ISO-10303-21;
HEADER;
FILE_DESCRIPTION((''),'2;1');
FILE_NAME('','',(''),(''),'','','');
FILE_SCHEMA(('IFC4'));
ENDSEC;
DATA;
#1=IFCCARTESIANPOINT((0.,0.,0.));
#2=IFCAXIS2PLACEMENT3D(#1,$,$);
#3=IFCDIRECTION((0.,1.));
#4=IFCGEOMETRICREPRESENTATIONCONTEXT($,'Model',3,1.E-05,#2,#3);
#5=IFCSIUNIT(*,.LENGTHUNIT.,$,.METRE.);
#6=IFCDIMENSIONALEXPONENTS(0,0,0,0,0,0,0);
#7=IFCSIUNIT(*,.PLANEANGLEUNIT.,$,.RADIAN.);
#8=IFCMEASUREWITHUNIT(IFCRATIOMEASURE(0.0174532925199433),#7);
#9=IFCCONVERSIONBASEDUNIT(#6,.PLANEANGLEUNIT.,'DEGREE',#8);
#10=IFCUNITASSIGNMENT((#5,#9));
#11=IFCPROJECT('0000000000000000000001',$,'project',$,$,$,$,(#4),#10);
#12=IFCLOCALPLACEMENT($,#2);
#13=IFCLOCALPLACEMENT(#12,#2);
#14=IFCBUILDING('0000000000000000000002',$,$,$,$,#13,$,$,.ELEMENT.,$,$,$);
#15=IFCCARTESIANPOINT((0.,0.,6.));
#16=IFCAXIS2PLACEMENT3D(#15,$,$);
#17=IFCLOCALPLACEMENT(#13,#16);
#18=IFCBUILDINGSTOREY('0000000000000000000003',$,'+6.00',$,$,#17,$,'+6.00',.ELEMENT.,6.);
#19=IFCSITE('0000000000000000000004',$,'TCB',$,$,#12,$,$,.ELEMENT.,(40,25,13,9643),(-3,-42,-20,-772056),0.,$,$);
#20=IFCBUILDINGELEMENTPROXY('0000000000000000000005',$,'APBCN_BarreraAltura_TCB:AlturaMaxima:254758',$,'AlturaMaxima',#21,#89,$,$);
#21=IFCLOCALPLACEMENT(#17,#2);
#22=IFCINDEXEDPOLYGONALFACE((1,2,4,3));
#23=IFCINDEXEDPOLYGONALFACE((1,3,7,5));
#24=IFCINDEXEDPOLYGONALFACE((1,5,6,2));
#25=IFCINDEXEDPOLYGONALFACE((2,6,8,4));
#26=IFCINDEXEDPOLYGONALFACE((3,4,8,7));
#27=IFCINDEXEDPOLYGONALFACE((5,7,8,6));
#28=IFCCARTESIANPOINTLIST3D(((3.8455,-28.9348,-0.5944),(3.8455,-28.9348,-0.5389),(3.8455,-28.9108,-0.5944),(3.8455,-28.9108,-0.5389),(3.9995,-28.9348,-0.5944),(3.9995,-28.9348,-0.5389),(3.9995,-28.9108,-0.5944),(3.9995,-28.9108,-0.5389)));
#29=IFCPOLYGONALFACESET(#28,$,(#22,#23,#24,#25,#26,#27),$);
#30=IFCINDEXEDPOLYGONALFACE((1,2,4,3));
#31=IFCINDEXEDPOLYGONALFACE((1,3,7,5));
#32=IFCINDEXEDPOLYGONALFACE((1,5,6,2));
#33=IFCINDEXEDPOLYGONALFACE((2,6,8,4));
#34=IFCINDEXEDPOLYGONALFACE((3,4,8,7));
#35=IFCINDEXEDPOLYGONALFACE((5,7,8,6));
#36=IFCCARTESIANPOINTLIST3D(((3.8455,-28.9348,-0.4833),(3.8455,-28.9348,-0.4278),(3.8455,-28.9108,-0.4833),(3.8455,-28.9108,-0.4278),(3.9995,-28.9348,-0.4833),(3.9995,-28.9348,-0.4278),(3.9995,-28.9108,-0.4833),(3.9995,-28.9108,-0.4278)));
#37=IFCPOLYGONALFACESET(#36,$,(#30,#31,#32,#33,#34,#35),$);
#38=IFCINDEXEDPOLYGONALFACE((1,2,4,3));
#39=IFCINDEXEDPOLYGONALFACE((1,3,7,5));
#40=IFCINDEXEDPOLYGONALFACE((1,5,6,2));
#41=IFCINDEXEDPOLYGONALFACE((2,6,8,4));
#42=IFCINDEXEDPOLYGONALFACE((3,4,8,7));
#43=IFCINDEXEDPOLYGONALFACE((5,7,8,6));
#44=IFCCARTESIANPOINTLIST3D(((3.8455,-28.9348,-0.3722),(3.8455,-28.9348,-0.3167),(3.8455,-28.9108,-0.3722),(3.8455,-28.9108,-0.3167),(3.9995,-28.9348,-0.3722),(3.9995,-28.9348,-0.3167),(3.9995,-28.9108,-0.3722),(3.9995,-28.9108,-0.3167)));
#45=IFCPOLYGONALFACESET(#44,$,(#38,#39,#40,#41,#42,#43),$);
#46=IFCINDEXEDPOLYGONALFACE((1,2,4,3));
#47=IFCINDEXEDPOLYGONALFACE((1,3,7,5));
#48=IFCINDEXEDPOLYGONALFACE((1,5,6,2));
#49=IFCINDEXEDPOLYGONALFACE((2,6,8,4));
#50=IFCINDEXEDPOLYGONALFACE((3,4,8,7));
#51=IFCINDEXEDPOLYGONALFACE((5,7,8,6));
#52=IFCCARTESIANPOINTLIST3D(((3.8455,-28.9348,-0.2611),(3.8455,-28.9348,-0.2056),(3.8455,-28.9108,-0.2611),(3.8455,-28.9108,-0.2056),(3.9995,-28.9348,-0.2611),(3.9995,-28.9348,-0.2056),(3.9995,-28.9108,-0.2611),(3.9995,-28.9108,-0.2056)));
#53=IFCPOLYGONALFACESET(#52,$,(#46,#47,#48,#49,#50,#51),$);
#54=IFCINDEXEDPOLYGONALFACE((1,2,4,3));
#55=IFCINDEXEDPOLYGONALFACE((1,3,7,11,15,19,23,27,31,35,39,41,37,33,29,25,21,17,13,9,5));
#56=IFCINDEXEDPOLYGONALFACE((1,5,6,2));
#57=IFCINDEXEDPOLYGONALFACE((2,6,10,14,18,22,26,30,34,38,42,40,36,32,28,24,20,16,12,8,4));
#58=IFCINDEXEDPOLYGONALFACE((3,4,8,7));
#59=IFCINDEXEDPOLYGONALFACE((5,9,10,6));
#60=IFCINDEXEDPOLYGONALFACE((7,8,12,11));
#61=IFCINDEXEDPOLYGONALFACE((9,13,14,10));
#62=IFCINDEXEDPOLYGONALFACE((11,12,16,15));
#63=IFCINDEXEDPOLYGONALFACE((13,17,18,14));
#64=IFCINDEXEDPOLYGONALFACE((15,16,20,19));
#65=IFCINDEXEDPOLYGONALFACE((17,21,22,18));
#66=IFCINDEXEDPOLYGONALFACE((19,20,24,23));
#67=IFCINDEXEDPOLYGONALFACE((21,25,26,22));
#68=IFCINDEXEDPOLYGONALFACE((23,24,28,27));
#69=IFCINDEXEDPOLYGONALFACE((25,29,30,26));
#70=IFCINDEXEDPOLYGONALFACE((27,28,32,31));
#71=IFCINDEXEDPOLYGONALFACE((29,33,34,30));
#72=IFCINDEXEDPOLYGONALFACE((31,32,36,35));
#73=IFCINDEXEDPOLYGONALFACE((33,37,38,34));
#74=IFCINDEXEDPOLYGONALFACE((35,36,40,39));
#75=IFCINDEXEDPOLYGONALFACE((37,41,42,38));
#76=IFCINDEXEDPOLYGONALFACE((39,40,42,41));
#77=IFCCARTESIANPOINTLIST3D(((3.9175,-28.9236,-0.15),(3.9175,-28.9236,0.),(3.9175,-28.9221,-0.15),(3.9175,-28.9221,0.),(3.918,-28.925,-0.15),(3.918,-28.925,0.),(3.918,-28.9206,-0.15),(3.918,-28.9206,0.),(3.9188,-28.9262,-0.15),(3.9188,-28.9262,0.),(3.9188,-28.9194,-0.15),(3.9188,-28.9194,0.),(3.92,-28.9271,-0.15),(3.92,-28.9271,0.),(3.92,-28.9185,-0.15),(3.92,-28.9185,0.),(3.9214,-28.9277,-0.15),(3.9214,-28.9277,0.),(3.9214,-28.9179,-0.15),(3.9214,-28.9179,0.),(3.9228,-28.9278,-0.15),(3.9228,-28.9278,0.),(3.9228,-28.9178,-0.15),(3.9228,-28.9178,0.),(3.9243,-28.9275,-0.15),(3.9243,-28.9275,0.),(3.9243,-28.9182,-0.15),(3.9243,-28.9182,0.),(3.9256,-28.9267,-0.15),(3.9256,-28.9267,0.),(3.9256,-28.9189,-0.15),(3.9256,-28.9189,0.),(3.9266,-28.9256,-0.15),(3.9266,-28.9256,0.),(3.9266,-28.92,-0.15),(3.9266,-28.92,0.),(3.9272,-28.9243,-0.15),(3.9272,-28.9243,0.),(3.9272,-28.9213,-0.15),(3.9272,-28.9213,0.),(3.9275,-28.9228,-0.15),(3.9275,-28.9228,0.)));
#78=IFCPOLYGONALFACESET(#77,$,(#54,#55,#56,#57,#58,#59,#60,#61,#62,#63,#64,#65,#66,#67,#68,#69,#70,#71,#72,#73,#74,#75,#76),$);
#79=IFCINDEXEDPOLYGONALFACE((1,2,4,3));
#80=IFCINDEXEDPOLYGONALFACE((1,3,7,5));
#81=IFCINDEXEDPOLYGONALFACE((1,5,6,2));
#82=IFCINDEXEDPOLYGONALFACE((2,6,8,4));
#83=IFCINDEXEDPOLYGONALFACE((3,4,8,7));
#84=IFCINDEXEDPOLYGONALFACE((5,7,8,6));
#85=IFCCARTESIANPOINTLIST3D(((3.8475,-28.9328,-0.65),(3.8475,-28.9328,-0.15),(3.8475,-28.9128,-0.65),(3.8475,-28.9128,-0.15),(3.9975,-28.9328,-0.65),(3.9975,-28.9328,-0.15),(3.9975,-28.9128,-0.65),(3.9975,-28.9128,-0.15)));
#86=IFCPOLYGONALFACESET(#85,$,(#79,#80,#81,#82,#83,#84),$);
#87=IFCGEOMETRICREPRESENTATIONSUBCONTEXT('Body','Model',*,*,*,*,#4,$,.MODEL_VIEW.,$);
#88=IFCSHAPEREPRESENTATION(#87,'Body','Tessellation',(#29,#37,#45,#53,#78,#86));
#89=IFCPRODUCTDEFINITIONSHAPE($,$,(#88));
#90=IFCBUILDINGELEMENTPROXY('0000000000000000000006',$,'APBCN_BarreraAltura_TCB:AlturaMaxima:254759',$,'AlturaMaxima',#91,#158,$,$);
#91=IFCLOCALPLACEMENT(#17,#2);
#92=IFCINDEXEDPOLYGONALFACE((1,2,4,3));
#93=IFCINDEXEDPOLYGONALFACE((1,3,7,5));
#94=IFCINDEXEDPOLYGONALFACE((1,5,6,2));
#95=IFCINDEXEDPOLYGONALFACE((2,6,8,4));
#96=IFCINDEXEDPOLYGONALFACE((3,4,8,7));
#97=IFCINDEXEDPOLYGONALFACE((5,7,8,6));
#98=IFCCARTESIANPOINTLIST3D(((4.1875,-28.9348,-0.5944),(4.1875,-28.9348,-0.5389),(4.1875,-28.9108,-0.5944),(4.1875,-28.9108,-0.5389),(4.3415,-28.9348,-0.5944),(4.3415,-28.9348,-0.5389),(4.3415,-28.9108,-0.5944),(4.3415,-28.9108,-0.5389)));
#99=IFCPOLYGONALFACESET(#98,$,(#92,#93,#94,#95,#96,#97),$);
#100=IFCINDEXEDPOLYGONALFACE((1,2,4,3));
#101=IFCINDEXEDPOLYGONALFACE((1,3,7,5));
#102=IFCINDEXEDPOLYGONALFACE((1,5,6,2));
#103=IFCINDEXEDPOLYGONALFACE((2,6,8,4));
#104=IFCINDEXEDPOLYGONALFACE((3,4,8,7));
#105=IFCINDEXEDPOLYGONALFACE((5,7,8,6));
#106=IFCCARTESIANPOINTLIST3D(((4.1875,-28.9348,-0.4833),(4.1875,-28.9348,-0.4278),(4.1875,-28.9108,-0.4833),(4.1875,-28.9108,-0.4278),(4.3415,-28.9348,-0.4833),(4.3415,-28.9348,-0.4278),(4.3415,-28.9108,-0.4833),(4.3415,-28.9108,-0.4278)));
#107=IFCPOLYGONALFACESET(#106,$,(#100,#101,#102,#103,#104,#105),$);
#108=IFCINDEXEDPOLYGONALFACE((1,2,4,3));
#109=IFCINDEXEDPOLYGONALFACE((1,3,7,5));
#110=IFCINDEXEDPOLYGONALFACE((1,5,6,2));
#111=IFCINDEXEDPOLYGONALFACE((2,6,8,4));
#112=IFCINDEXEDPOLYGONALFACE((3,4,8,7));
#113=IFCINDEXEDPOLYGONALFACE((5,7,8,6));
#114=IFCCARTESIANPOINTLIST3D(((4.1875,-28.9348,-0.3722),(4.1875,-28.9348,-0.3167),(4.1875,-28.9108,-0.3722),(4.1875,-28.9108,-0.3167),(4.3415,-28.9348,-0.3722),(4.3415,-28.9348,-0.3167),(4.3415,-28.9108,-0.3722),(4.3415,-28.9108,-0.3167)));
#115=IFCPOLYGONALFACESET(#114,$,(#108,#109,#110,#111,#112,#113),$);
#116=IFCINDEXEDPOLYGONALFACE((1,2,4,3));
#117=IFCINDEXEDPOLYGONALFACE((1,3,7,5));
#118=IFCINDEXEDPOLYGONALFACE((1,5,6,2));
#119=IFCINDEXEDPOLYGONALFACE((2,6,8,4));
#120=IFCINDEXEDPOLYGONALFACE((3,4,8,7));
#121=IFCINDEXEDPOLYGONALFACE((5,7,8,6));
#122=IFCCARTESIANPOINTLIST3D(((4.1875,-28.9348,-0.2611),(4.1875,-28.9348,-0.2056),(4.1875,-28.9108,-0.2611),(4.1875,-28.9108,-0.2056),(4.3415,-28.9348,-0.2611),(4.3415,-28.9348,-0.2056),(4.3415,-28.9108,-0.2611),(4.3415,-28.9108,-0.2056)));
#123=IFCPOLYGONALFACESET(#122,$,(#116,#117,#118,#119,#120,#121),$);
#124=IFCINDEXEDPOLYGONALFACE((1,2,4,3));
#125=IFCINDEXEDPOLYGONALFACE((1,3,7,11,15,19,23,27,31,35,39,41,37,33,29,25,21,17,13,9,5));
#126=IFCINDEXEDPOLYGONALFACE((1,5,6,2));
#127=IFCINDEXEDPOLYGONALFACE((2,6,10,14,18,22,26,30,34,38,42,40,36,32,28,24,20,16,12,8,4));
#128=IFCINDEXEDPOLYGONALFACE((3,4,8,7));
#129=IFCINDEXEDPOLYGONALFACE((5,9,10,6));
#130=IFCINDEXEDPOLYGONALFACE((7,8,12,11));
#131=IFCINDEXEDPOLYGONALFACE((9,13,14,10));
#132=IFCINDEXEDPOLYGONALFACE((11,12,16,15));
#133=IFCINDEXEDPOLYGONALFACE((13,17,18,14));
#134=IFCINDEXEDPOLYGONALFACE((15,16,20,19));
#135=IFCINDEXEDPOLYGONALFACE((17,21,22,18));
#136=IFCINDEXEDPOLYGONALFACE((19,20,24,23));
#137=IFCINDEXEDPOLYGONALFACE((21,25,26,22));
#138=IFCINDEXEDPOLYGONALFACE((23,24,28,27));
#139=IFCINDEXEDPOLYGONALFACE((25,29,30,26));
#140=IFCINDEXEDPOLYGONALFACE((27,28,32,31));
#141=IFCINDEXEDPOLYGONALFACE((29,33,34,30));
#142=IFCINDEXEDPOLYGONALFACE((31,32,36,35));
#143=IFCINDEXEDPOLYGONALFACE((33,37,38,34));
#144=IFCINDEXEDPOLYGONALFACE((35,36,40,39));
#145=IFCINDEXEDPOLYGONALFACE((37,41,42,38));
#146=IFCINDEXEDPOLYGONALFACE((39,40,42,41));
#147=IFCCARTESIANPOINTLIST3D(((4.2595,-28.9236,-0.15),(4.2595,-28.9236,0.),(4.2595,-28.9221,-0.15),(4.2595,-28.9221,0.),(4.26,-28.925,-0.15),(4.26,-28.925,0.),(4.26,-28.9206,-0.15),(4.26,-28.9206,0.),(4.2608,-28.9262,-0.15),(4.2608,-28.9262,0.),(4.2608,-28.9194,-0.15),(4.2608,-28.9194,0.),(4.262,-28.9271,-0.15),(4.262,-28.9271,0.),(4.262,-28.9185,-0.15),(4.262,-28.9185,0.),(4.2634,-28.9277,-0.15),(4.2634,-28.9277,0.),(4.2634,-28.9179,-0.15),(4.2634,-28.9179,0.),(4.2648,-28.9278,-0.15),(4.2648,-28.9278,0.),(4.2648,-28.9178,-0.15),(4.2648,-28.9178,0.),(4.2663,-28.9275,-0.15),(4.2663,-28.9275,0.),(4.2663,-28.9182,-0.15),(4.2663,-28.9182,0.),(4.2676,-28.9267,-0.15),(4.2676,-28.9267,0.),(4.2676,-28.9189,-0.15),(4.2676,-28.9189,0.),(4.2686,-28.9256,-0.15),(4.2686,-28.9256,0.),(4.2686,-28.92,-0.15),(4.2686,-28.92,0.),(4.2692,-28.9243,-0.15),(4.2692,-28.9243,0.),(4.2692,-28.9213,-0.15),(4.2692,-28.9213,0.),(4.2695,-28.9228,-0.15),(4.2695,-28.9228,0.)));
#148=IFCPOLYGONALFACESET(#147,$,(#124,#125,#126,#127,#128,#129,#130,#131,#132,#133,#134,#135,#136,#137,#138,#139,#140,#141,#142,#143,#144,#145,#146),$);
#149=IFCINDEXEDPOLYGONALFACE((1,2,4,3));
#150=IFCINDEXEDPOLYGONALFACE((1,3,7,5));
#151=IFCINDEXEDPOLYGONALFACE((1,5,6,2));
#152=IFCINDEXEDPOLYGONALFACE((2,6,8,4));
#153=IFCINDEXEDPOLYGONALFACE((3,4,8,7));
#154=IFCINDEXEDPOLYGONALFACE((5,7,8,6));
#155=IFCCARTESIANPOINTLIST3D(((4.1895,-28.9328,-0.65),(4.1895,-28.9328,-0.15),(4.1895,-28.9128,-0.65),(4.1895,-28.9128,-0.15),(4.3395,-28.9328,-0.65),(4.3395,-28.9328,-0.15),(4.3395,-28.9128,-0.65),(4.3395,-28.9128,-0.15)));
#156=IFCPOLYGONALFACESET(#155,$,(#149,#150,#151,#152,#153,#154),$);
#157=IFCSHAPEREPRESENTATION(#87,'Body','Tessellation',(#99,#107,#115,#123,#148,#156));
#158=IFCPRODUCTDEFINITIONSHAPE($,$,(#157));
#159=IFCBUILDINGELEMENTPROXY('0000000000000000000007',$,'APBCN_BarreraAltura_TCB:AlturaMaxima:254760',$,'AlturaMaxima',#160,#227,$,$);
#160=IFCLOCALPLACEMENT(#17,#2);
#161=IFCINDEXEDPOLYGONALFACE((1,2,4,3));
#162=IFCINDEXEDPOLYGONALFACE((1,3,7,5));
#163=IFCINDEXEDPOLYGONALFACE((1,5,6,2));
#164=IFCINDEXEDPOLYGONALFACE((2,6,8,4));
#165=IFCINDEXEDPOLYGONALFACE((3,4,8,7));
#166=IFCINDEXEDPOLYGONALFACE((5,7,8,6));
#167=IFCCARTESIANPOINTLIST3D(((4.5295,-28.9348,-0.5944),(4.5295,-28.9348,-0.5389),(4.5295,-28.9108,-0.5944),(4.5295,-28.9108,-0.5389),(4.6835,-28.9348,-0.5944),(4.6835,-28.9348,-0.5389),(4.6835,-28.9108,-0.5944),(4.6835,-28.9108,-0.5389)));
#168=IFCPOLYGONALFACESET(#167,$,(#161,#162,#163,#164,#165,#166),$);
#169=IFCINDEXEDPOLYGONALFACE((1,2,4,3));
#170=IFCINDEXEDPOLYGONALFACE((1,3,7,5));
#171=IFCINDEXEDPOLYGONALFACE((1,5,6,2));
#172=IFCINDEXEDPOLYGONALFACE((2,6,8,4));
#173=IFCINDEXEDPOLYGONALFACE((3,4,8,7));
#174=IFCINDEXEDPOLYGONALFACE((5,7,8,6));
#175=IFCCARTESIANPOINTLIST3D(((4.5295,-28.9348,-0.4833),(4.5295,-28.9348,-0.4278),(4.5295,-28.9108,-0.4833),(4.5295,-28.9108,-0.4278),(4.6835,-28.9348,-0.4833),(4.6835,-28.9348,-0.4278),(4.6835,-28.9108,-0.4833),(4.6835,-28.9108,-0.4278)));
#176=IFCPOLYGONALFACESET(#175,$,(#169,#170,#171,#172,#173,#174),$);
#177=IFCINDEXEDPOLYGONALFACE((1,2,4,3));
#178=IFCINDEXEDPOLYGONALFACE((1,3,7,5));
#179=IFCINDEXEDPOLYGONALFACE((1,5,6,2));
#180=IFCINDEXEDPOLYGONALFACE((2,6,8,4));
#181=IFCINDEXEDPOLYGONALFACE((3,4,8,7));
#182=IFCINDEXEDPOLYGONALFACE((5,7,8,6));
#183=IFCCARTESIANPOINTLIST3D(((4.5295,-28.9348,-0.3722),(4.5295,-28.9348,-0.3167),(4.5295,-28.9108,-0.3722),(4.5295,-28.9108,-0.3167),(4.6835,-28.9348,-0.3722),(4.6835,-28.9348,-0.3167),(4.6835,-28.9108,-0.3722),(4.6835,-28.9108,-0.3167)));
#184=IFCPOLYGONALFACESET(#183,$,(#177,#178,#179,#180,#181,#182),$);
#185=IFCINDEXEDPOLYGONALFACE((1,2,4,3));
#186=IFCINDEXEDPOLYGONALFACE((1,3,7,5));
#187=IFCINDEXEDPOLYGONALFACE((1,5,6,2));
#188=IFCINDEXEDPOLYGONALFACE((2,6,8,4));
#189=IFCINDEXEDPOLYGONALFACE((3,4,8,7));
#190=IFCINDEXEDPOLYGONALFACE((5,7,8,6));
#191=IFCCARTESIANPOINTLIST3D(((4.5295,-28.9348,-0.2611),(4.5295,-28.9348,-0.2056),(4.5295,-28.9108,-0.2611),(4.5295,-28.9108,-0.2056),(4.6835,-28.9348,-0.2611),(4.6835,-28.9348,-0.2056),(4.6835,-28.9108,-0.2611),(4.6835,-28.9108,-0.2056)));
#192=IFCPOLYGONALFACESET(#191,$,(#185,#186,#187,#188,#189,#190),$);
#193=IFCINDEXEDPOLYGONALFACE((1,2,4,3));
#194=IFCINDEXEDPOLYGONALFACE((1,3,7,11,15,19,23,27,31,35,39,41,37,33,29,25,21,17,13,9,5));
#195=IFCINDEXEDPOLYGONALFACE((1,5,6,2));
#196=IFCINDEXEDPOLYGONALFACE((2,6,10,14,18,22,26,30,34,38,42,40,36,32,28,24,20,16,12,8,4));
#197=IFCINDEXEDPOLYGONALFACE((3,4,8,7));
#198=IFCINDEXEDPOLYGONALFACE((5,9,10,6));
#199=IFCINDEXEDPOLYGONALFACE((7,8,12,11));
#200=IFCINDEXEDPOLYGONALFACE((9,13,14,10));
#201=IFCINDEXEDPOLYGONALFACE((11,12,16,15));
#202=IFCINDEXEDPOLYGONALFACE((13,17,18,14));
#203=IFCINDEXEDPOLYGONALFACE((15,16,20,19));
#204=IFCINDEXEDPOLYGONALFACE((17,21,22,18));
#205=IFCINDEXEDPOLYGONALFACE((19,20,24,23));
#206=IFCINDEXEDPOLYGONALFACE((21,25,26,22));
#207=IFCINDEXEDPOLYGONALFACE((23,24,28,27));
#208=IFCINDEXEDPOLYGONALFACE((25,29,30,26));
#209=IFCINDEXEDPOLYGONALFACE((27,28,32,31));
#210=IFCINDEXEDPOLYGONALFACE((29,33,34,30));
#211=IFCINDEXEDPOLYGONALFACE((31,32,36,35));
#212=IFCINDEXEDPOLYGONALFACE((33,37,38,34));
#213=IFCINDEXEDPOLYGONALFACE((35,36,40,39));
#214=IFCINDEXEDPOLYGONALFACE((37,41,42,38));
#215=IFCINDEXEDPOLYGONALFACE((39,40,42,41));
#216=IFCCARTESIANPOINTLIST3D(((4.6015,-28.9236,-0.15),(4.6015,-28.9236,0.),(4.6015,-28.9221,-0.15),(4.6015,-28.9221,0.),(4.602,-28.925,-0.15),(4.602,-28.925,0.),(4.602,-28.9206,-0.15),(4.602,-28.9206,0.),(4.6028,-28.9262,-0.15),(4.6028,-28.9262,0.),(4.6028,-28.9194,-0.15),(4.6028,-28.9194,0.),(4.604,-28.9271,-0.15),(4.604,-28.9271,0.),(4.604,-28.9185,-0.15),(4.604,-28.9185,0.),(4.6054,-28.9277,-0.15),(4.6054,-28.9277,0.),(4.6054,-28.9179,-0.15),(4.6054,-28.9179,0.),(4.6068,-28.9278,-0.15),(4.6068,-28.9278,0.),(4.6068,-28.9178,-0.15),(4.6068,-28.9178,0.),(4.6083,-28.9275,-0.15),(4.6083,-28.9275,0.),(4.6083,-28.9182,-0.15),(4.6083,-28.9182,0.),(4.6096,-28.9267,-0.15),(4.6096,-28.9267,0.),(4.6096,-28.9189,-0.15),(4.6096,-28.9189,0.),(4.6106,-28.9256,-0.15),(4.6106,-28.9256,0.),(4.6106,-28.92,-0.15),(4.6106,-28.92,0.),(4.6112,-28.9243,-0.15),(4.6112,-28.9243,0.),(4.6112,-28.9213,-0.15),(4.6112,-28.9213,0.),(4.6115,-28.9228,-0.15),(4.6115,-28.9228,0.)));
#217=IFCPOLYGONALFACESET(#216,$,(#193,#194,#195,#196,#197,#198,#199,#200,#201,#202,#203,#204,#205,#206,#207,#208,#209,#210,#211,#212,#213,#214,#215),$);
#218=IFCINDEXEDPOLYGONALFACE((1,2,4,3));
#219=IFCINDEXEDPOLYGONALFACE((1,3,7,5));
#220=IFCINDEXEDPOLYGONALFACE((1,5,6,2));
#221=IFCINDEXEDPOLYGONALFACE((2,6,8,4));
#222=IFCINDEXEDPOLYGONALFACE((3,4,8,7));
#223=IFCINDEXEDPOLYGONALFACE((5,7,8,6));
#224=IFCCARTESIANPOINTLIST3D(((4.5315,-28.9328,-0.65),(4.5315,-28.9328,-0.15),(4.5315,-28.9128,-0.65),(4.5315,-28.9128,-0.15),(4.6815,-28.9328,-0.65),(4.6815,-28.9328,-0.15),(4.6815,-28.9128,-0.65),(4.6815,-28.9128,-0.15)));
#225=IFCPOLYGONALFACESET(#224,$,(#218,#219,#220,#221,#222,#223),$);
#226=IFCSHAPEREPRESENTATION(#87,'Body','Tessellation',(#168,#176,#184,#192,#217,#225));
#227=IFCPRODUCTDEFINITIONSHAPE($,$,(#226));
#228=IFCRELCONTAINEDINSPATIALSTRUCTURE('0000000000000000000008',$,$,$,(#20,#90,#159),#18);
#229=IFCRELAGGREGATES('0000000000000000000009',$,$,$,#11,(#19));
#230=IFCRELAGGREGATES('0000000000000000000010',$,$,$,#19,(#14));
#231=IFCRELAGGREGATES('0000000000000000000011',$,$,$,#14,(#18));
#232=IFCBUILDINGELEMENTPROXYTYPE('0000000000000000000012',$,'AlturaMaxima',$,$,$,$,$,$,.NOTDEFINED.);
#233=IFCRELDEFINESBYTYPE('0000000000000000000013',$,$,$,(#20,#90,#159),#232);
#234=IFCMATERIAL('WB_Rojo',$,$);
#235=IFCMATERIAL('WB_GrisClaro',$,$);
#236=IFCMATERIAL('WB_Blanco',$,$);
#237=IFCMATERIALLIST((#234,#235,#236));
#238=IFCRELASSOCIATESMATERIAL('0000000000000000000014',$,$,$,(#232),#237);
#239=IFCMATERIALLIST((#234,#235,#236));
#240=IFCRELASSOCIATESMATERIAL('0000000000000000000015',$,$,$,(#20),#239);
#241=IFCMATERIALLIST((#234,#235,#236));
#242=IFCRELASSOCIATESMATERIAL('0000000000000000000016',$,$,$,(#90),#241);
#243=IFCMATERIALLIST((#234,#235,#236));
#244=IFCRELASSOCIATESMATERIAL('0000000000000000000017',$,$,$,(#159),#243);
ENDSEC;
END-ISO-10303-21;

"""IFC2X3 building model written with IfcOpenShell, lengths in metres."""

from ifc_helpers import new_model, entity, si_unit, converted_unit, direction, frame, frame_2d, origin, origin_2d_with_axis, place, context, subcontext, project, spatial, rectangle, circle, extrude, source, transform, mapped, material, material_list, type_object, type_shapes, element, save


model = new_model("IFC2X3")

# Units and contexts
model_context = context("Model", 3, precision=1e-05, world=origin(), true_north=direction((0.0, 1.0)))
body_context = subcontext(model_context, "Body", "Model", "MODEL_VIEW")
ifc_project = project(units=[si_unit("LENGTHUNIT", "METRE"), converted_unit("PLANEANGLEUNIT", "DEGREE", entity("IfcRatioMeasure", 0.0174532925199433), si_unit("PLANEANGLEUNIT", "RADIAN"), dimensions=[0, 0, 0, 0, 0, 0, 0])], contexts=[model_context])

# Site, building, storey
site_placement = place(None, origin())
site = spatial("IfcSite", under=ifc_project, at=site_placement, Name="TCB", CompositionType="ELEMENT", RefLatitude=(40, 25, 13, 9643), RefLongitude=(-3, -42, -20, -772056), RefElevation=0.0)
building_placement = place(site_placement, origin())
building = spatial("IfcBuilding", under=site, at=building_placement, CompositionType="ELEMENT")
storey_placement = place(building_placement, frame((0.0, 0.0, 6.0)))
storey = spatial("IfcBuildingStorey", under=building, at=storey_placement, Name="+6.00", LongName="+6.00", CompositionType="ELEMENT", Elevation=6.0)

# Building element proxies
ifc_material_1 = material(Name="WB_Rojo")
ifc_material_2 = material(Name="WB_GrisClaro")
ifc_material_3 = material(Name="WB_Blanco")
ifc_material_list_1 = material_list([ifc_material_1, ifc_material_2, ifc_material_3])
building_element_proxy_type = type_object("IfcBuildingElementProxyType", Name="AlturaMaxima", PredefinedType="NOTDEFINED", material=ifc_material_list_1)
shared_shape = source(origin(), body_context, "Body", "SweptSolid", [
    extrude(rectangle(XDim=0.154, YDim=0.024, at=frame_2d((0.0, 0.0), x_axis=(1.0, 0.0))), frame((0.0, 0.0, -0.5944), z_axis=(0.0, 0.0, 1.0), x_axis=(-1.0, 0.0, 0.0)), (0.0, 0.0, 1.0), 0.0556),
    extrude(rectangle(XDim=0.154, YDim=0.024, at=frame_2d((0.0, 0.0), x_axis=(1.0, 0.0))), frame((0.0, 0.0, -0.4833), z_axis=(0.0, 0.0, 1.0), x_axis=(-1.0, 0.0, 0.0)), (0.0, 0.0, 1.0), 0.0556),
    extrude(rectangle(XDim=0.154, YDim=0.024, at=frame_2d((0.0, 0.0), x_axis=(1.0, 0.0))), frame((0.0, 0.0, -0.3722), z_axis=(0.0, 0.0, 1.0), x_axis=(-1.0, 0.0, 0.0)), (0.0, 0.0, 1.0), 0.0556),
    extrude(rectangle(XDim=0.154, YDim=0.024, at=frame_2d((0.0, 0.0), x_axis=(1.0, 0.0))), frame((0.0, 0.0, -0.2611), z_axis=(0.0, 0.0, 1.0), x_axis=(-1.0, 0.0, 0.0)), (0.0, 0.0, 1.0), 0.0556),
    extrude(circle(Radius=0.005, at=frame_2d((0.0, 0.0), x_axis=(1.0, 0.0))), frame((0.0, 0.0, -0.15)), (0.0, 0.0, 1.0), 0.15),
    extrude(rectangle(XDim=0.02, YDim=0.15, at=origin_2d_with_axis()), frame((0.0, 0.0, -0.65), z_axis=(0.0, 0.0, 1.0), x_axis=(0.0, 1.0, 0.0)), (0.0, 0.0, 1.0), 0.5),
])
type_shapes(building_element_proxy_type, [shared_shape])
ifc_material_list_2 = material_list([ifc_material_1, ifc_material_2, ifc_material_3])
proxy_1_placement = place(storey_placement, frame((3.9225, -28.9228, 0.0)))
element("IfcBuildingElementProxy", 1, at=proxy_1_placement, inside=storey, type_object=building_element_proxy_type, material=ifc_material_list_2, Name="APBCN_BarreraAltura_TCB:AlturaMaxima:254758", ObjectType="AlturaMaxima", context=body_context, shape_type="MappedRepresentation", body=[
    mapped(shared_shape, transform((0.0, 0.0, 0.0), scale=1.0)),
])
ifc_material_list_3 = material_list([ifc_material_1, ifc_material_2, ifc_material_3])
proxy_2_placement = place(storey_placement, frame((4.2645, -28.9228, 0.0)))
element("IfcBuildingElementProxy", 2, at=proxy_2_placement, inside=storey, type_object=building_element_proxy_type, material=ifc_material_list_3, Name="APBCN_BarreraAltura_TCB:AlturaMaxima:254759", ObjectType="AlturaMaxima", context=body_context, shape_type="MappedRepresentation", body=[
    mapped(shared_shape, transform((0.0, 0.0, 0.0), scale=1.0)),
])
ifc_material_list_4 = material_list([ifc_material_1, ifc_material_2, ifc_material_3])
proxy_3_placement = place(storey_placement, frame((4.6065, -28.9228, 0.0)))
element("IfcBuildingElementProxy", 3, at=proxy_3_placement, inside=storey, type_object=building_element_proxy_type, material=ifc_material_list_4, Name="APBCN_BarreraAltura_TCB:AlturaMaxima:254760", ObjectType="AlturaMaxima", context=body_context, shape_type="MappedRepresentation", body=[
    mapped(shared_shape, transform((0.0, 0.0, 0.0), scale=1.0)),
])

save(model, "model.ifc")
